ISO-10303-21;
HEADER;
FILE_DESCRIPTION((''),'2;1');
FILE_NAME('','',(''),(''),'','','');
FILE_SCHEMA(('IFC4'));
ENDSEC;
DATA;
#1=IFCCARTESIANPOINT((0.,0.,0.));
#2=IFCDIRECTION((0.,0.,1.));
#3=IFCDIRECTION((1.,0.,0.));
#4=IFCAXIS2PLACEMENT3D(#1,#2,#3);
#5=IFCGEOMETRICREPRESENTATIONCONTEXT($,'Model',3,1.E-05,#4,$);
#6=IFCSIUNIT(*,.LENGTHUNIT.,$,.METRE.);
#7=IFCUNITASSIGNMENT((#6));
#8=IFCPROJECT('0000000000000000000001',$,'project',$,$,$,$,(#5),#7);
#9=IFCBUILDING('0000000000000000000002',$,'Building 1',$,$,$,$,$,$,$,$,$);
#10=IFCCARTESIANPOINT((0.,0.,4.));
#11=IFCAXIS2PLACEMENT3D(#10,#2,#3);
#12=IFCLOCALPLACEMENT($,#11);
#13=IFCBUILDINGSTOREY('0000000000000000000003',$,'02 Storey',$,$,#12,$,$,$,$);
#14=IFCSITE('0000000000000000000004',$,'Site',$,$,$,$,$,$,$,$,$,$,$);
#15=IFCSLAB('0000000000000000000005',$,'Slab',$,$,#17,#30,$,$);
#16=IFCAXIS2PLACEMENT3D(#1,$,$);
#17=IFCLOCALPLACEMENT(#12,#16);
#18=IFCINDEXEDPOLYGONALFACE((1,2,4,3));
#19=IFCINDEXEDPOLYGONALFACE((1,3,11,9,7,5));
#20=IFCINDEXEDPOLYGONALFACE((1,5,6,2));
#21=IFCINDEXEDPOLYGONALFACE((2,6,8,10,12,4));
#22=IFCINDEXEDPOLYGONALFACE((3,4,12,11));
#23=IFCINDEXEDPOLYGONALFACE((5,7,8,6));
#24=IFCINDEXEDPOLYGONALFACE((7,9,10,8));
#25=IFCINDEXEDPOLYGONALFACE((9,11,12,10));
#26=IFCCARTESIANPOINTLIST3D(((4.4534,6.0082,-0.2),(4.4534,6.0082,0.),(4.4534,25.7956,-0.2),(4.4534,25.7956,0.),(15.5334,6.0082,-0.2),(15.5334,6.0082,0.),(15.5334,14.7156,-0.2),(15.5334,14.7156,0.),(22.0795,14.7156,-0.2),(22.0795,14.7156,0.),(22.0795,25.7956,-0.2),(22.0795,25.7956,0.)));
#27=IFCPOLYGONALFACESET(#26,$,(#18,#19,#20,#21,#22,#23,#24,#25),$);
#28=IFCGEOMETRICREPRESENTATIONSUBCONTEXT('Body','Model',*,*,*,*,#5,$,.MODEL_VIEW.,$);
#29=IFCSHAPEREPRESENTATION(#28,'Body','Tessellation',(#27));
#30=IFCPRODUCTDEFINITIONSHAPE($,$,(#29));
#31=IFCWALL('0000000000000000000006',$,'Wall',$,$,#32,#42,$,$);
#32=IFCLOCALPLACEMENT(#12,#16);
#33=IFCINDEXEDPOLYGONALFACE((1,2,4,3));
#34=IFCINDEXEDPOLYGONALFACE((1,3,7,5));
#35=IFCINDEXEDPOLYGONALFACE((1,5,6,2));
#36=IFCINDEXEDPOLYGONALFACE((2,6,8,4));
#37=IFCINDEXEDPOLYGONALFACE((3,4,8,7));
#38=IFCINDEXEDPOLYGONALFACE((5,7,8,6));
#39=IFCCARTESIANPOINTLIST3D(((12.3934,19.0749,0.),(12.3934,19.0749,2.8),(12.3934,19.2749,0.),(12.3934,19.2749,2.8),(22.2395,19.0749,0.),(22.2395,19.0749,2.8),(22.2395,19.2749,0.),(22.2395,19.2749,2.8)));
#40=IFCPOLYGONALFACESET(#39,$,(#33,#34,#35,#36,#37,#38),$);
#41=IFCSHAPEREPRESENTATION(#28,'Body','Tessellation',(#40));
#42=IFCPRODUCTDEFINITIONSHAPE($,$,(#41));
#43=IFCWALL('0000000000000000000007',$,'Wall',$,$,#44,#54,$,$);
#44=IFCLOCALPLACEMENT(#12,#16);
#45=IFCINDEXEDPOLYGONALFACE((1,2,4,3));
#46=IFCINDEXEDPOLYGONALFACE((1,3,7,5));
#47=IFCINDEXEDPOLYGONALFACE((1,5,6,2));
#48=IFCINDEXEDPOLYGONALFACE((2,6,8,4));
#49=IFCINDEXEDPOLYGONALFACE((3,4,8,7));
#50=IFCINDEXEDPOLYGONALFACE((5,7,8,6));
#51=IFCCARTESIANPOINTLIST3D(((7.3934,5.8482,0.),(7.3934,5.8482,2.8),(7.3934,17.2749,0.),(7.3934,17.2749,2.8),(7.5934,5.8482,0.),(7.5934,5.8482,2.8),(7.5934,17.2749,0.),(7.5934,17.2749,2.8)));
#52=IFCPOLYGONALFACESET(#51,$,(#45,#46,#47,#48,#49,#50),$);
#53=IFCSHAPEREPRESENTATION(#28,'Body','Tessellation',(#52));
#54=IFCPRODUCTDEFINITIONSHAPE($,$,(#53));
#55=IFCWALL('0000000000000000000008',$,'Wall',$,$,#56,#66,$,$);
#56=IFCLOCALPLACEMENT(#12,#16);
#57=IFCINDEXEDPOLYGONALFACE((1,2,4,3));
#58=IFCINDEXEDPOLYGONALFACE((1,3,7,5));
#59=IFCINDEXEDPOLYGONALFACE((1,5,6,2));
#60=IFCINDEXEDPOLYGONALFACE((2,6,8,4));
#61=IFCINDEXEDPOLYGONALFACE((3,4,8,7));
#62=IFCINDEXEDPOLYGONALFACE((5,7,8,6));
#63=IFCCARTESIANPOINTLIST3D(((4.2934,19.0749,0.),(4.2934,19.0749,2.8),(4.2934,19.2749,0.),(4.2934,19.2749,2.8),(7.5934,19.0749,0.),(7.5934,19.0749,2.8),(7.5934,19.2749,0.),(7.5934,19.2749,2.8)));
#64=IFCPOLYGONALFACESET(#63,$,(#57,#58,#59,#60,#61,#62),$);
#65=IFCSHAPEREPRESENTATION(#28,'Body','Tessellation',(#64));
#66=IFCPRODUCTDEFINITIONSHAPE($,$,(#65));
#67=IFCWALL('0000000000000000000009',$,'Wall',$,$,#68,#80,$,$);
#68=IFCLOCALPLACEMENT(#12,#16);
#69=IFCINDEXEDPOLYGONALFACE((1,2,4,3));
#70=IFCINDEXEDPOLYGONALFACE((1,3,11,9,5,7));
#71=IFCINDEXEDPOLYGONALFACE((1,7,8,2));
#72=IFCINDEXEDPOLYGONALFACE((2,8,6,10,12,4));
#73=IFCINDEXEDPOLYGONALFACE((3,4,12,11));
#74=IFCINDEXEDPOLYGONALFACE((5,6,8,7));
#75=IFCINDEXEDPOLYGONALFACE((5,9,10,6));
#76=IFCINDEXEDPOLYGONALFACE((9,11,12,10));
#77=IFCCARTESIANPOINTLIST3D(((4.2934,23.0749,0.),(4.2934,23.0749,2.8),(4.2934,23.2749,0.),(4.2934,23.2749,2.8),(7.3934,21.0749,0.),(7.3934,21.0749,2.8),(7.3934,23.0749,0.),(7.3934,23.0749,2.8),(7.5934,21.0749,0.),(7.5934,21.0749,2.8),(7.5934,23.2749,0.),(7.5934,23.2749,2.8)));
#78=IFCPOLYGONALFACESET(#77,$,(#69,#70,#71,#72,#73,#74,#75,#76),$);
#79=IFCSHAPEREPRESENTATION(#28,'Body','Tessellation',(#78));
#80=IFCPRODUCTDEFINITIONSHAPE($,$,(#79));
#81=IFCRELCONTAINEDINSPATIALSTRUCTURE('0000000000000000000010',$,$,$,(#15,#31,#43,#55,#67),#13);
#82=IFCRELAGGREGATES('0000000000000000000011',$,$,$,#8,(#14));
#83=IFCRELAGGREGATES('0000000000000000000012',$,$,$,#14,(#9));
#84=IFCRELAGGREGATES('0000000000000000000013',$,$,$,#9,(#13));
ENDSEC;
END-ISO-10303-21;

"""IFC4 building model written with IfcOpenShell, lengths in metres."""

from ifc_helpers import new_model, si_unit, frame, origin_with_axes, place, context, subcontext, project, spatial, line, indexed_curve, outline, extrude, element, save


model = new_model("IFC4")

# Units and contexts
model_context = context("Model", 3, precision=1e-05, world=origin_with_axes())
body_context = subcontext(model_context, "Body", "Model", "MODEL_VIEW")
ifc_project = project(units=[si_unit("LENGTHUNIT", "METRE")], contexts=[model_context])

# Site, building, storey
site = spatial("IfcSite", under=ifc_project, Name="Site")
building = spatial("IfcBuilding", under=site, Name="Building 1")
storey_placement = place(None, frame((0.0, 0.0, 4.0), z_axis=(0.0, 0.0, 1.0), x_axis=(1.0, 0.0, 0.0)))
storey = spatial("IfcBuildingStorey", under=building, at=storey_placement, Name="02 Storey")

# Slab
slab_placement = place(storey_placement, origin_with_axes())
element("IfcSlab", 1, at=slab_placement, inside=storey, Name="Slab", context=body_context, shape_type="SweptSolid", body=[
    extrude(outline(indexed_curve([(15.5334, 14.7156), (22.0795, 14.7156), (22.0795, 25.7956), (4.4534, 25.7956), (4.4534, 6.0082), (15.5334, 6.0082)], segments=[line(1, 2), line(2, 3), line(3, 4), line(4, 5), line(5, 6)])), origin_with_axes(), (0.0, 0.0, -1.0), 0.2),
])

# Walls
wall_1_placement = place(storey_placement, origin_with_axes())
element("IfcWall", 2, at=wall_1_placement, inside=storey, Name="Wall", context=body_context, shape_type="SweptSolid", body=[
    extrude(outline(indexed_curve([(22.2395, 19.2749), (12.3934, 19.2749), (12.3934, 19.0749), (22.2395, 19.0749)], segments=[line(1, 2), line(2, 3), line(3, 4)])), origin_with_axes(), (0.0, 0.0, 1.0), 2.8),
])
wall_2_placement = place(storey_placement, origin_with_axes())
element("IfcWall", 3, at=wall_2_placement, inside=storey, Name="Wall", context=body_context, shape_type="SweptSolid", body=[
    extrude(outline(indexed_curve([(7.5934, 17.2749), (7.3934, 17.2749), (7.3934, 5.8482), (7.5934, 5.8482)], segments=[line(1, 2), line(2, 3), line(3, 4)])), origin_with_axes(), (0.0, 0.0, 1.0), 2.8),
])
wall_3_placement = place(storey_placement, origin_with_axes())
element("IfcWall", 4, at=wall_3_placement, inside=storey, Name="Wall", context=body_context, shape_type="SweptSolid", body=[
    extrude(outline(indexed_curve([(7.5934, 19.2749), (4.2934, 19.2749), (4.2934, 19.0749), (7.5934, 19.0749)], segments=[line(1, 2), line(2, 3), line(3, 4)])), origin_with_axes(), (0.0, 0.0, 1.0), 2.8),
])
wall_4_placement = place(storey_placement, origin_with_axes())
element("IfcWall", 5, at=wall_4_placement, inside=storey, Name="Wall", context=body_context, shape_type="SweptSolid", body=[
    extrude(outline(indexed_curve([(7.5934, 23.2749), (4.2934, 23.2749), (4.2934, 23.0749), (7.3934, 23.0749), (7.3934, 21.0749), (7.5934, 21.0749)], segments=[line(1, 2), line(2, 3), line(3, 4), line(4, 5), line(5, 6)])), origin_with_axes(), (0.0, 0.0, 1.0), 2.8),
])

save(model, "model.ifc")
